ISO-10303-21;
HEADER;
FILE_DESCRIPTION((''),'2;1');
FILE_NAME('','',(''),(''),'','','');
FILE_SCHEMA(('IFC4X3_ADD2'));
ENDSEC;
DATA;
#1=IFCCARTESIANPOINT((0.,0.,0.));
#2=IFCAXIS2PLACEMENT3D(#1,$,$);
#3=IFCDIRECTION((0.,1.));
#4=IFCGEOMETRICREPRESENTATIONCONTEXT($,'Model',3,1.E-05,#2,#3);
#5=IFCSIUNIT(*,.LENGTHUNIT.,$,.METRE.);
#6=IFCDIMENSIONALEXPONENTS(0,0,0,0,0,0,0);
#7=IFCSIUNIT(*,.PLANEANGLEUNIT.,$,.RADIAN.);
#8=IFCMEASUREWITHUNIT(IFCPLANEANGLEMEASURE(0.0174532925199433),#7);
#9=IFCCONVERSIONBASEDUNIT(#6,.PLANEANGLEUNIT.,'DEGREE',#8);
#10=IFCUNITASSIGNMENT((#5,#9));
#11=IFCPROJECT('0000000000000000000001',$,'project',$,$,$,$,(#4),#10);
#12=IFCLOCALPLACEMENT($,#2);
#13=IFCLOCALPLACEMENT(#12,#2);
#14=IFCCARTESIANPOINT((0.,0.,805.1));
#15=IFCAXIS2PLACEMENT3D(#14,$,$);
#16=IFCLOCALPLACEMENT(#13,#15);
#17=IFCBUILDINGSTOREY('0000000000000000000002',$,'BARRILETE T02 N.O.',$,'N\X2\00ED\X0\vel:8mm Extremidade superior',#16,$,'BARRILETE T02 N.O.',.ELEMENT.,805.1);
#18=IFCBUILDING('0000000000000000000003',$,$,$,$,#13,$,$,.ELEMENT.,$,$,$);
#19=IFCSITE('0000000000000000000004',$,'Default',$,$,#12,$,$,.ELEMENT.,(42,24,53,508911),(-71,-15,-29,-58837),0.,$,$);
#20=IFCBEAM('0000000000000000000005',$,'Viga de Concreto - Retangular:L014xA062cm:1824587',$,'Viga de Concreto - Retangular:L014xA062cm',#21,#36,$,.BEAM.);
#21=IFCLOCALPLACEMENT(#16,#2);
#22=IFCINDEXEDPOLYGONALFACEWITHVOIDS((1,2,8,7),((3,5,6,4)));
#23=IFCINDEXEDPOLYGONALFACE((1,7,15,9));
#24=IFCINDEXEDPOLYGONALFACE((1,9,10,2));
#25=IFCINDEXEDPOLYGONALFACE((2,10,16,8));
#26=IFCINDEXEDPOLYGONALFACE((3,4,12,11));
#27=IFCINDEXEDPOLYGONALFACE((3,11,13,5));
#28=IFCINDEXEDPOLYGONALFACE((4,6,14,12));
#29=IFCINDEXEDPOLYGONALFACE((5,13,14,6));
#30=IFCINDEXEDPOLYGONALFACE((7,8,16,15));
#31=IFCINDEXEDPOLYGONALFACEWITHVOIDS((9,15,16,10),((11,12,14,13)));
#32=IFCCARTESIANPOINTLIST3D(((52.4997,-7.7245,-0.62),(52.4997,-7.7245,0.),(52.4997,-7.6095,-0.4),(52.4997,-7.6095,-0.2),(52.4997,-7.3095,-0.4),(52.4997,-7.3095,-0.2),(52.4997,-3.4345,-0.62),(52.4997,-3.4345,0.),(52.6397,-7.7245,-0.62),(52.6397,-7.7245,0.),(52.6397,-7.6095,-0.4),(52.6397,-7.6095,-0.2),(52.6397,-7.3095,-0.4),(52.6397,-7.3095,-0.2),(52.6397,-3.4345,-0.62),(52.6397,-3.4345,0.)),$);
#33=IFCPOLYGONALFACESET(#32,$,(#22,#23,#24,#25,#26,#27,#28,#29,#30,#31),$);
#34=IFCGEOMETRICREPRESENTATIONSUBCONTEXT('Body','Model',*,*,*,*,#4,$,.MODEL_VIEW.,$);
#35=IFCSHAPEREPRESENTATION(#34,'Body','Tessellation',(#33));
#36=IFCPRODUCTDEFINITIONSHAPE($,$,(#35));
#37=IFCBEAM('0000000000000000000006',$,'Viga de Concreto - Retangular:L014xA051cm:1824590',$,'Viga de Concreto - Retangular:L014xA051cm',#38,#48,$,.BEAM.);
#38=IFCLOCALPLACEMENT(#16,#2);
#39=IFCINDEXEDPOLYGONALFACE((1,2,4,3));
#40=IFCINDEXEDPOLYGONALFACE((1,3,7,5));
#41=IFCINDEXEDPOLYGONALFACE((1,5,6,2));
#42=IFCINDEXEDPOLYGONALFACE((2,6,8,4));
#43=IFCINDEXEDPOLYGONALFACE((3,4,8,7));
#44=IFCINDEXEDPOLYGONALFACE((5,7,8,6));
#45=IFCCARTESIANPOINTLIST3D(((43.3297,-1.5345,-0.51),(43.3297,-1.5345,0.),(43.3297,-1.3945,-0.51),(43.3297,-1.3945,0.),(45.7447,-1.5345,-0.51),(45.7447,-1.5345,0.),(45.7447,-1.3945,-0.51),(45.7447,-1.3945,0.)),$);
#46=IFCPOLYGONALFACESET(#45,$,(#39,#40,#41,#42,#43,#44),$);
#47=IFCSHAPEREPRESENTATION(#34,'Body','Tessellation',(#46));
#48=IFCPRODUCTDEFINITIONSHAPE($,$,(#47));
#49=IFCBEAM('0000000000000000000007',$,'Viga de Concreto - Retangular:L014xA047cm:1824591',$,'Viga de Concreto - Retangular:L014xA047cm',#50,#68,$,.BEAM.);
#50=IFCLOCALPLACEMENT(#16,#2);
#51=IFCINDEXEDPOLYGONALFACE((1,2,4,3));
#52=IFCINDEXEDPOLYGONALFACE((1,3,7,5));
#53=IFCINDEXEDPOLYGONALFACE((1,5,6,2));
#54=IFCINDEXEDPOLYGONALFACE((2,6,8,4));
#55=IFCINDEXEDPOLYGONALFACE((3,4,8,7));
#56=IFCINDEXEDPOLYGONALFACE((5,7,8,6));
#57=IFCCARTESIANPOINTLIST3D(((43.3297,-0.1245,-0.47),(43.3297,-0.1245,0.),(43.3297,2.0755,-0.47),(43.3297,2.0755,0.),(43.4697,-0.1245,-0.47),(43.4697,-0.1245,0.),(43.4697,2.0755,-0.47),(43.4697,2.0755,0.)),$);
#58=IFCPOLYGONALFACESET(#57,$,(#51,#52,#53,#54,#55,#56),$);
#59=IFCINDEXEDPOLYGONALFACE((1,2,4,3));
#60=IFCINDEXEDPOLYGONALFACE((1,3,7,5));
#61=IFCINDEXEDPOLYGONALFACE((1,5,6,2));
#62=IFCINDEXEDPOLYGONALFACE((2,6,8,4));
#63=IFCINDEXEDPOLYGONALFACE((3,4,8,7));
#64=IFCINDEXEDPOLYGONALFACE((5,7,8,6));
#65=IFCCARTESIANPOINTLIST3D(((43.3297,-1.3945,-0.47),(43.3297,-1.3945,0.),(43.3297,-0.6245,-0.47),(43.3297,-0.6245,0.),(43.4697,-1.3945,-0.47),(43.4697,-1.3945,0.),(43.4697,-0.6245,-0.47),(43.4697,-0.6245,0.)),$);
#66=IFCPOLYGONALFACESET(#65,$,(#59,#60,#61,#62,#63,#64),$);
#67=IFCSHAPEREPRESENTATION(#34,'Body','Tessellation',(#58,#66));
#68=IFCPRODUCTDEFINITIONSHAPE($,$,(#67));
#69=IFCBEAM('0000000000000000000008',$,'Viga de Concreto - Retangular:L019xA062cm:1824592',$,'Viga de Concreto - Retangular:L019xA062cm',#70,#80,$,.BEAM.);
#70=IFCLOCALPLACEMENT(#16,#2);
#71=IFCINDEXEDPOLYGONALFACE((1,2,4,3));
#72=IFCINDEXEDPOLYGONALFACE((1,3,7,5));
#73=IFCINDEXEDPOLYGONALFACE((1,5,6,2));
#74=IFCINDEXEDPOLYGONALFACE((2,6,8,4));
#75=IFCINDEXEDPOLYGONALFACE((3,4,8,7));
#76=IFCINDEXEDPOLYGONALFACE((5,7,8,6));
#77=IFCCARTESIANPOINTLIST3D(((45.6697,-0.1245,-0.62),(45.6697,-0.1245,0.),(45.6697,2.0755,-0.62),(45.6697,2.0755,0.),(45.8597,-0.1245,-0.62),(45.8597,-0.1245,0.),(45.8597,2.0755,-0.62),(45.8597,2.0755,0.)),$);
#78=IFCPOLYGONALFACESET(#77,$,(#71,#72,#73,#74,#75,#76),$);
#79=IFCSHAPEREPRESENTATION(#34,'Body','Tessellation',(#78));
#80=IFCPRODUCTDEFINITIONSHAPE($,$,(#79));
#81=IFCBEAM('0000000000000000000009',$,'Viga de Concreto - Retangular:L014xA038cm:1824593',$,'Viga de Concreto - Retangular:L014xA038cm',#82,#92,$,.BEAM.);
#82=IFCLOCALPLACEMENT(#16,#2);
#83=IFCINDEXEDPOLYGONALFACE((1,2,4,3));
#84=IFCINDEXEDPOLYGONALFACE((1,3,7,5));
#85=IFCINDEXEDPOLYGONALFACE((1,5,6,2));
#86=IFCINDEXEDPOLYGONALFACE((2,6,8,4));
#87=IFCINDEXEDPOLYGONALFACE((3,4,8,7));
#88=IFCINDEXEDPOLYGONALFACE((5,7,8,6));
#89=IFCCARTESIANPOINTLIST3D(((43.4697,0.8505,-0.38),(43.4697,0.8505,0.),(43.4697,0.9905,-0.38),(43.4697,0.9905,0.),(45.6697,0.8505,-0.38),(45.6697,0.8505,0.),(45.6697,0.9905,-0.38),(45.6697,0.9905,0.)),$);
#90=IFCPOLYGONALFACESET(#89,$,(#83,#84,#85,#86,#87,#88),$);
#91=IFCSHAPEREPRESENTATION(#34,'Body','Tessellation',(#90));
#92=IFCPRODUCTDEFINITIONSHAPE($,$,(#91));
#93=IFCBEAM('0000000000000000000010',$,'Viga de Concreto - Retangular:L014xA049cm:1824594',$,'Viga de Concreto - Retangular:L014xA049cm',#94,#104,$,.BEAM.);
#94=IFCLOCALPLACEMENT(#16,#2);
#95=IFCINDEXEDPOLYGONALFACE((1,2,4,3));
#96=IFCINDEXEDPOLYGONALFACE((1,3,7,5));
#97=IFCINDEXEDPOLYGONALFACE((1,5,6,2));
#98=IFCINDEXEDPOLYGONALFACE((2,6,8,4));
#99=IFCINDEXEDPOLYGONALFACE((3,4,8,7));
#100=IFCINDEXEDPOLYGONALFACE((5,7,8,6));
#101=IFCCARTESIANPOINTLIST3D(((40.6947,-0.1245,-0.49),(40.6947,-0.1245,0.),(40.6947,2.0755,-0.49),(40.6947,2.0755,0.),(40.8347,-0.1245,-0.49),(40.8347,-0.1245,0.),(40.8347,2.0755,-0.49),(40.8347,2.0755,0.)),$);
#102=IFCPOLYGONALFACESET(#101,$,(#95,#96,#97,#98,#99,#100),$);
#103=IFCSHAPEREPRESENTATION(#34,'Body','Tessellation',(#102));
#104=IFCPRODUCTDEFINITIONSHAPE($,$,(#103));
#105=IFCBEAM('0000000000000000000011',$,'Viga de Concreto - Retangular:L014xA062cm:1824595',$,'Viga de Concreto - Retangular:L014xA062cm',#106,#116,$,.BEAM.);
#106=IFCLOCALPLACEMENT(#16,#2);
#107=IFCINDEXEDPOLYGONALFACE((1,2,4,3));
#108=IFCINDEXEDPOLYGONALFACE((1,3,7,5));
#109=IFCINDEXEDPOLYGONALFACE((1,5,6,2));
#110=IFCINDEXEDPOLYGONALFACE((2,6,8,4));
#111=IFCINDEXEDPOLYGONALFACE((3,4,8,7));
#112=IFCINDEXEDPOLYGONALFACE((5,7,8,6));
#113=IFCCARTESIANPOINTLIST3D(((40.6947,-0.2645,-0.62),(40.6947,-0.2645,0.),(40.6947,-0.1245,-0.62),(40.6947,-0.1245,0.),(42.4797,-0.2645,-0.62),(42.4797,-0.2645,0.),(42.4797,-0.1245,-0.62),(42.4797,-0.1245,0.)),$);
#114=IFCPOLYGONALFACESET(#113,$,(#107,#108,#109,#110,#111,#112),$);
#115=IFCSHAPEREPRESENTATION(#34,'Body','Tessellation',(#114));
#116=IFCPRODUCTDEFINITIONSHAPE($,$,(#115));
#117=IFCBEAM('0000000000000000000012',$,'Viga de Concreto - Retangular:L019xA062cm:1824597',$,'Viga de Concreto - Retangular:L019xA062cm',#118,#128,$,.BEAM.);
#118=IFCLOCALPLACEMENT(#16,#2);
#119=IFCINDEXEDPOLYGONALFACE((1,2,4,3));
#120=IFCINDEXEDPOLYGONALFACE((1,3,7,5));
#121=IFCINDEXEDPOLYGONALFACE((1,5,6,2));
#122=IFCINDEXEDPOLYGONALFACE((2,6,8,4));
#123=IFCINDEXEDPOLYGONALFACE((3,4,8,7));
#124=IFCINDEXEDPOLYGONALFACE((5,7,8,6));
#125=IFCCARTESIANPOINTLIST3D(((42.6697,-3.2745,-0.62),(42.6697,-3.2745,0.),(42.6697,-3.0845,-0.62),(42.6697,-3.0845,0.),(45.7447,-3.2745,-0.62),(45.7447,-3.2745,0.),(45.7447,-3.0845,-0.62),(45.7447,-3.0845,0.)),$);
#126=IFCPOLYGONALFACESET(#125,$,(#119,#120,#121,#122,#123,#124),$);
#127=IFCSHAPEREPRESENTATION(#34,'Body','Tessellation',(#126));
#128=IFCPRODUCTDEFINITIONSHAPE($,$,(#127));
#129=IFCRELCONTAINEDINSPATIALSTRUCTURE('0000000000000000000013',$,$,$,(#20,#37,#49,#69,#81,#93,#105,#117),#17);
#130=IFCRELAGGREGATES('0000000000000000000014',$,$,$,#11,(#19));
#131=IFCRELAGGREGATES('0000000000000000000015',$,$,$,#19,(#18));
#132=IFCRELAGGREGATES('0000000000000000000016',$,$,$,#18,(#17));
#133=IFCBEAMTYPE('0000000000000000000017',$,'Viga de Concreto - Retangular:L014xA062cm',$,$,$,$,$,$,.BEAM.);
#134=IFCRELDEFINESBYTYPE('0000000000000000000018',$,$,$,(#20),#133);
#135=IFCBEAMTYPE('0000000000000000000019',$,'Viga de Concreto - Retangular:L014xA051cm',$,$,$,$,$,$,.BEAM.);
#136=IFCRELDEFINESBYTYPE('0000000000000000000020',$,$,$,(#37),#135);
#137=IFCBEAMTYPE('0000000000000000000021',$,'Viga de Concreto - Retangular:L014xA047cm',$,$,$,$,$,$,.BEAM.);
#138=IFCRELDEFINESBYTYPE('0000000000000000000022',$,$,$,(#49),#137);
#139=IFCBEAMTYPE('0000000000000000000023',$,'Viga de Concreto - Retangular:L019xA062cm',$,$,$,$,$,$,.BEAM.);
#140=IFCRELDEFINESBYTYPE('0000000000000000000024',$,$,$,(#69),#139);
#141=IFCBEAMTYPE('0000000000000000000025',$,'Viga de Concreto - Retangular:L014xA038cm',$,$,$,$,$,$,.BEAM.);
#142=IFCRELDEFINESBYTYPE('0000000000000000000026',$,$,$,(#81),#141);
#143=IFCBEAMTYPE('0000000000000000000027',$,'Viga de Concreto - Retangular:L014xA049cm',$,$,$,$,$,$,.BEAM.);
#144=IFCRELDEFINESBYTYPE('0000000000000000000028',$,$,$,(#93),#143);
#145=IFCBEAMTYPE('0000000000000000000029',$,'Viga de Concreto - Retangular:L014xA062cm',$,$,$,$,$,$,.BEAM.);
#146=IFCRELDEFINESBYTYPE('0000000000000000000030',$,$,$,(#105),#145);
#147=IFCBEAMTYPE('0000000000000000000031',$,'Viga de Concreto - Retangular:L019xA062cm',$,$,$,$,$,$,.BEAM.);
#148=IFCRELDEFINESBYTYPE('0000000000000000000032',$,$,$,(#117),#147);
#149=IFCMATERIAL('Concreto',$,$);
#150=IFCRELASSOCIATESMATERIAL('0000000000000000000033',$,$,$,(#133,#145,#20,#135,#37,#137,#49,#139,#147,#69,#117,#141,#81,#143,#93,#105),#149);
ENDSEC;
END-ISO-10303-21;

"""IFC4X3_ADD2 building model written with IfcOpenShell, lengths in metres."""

from ifc_helpers import new_model, entity, si_unit, converted_unit, direction, frame, frame_2d, origin, place, context, subcontext, project, spatial, polyline, segment, composite_curve, rectangle, outline, extrude, boolean, source, transform, mapped, material, material_profile, profile_set, profile_usage, type_object, type_shapes, element, save


model = new_model("IFC4X3_ADD2")

# Units and contexts
model_context = context("Model", 3, precision=1e-05, world=origin(), true_north=direction((0.0, 1.0)))
body_context = subcontext(model_context, "Body", "Model", "MODEL_VIEW")
ifc_project = project(units=[si_unit("LENGTHUNIT", "METRE"), converted_unit("PLANEANGLEUNIT", "DEGREE", entity("IfcPlaneAngleMeasure", 0.0174532925199433), si_unit("PLANEANGLEUNIT", "RADIAN"), dimensions=[0, 0, 0, 0, 0, 0, 0])], contexts=[model_context])

# Site, building, storey
site_placement = place(None, origin())
site = spatial("IfcSite", under=ifc_project, at=site_placement, Name="Default", CompositionType="ELEMENT", RefLatitude=(42, 24, 53, 508911), RefLongitude=(-71, -15, -29, -58837), RefElevation=0.0)
building_placement = place(site_placement, origin())
building = spatial("IfcBuilding", under=site, at=building_placement, CompositionType="ELEMENT")
storey_placement = place(building_placement, frame((0.0, 0.0, 805.1)))
storey = spatial("IfcBuildingStorey", under=building, at=storey_placement, Name="BARRILETE T02 N.O.", ObjectType="Nível:8mm Extremidade superior", LongName="BARRILETE T02 N.O.", CompositionType="ELEMENT", Elevation=805.1)

# Shared definitions
ifc_material = material(Name="Concreto")

# Beams
ifc_material_profile_1 = material_profile(ifc_material, rectangle(XDim=0.62, YDim=0.19, at=frame_2d((0.0, 0.0), x_axis=(0.0, 1.0))), Name="L019xA062cm")
ifc_profile_set_1 = profile_set([ifc_material_profile_1], Name="L019xA062cm")
ifc_material_profile_2 = material_profile(ifc_material, rectangle(XDim=0.49, YDim=0.14, at=frame_2d((0.0, 0.0), x_axis=(0.0, 1.0))), Name="L014xA049cm")
ifc_profile_set_2 = profile_set([ifc_material_profile_2], Name="L014xA049cm")
ifc_profile_usage_1 = profile_usage(ifc_profile_set_2, cardinal=8)
ifc_profile_usage_2 = profile_usage(ifc_profile_set_1, cardinal=8)
ifc_material_profile_3 = material_profile(ifc_material, outline(composite_curve([segment(polyline([(-0.07, 0.31, 0.0), (0.07, 0.31, 0.0)]), True, "CONTINUOUS"), segment(polyline([(0.07, 0.31, 0.0), (0.07, -0.31, 0.0)]), True, "CONTINUOUS"), segment(polyline([(0.07, -0.31, 0.0), (-0.07, -0.31, 0.0)]), True, "CONTINUOUS"), segment(polyline([(-0.07, -0.31, 0.0), (-0.07, 0.31, 0.0)]), True, "CONTINUOUS")], self_intersect=False), kind="CURVE"), Name="L014xA062cm")
ifc_material_profile_4 = material_profile(ifc_material, outline(composite_curve([segment(polyline([(-2.2225, 0.07, 0.31), (-2.2225, 0.07, -0.31)]), True, "CONTINUOUS"), segment(polyline([(-2.2225, 0.07, -0.31), (-2.2225, -0.07, -0.31)]), True, "CONTINUOUS"), segment(polyline([(-2.2225, -0.07, -0.31), (-2.2225, -0.07, 0.31)]), True, "CONTINUOUS"), segment(polyline([(-2.2225, -0.07, 0.31), (-2.2225, 0.07, 0.31)]), True, "CONTINUOUS")], self_intersect=False), kind="CURVE"), Name="L014xA062cm")
ifc_profile_set_3 = profile_set([ifc_material_profile_3, ifc_material_profile_4], Name="L014xA062cm")
beam_type_1 = type_object("IfcBeamType", Name="Viga de Concreto - Retangular:L014xA062cm", PredefinedType="BEAM", material=ifc_profile_set_3)
shared_shape_1 = source(origin(), body_context, "Body", "CSG", [
    boolean("DIFFERENCE", extrude(rectangle(XDim=0.62, YDim=0.14, at=frame_2d((0.0, 0.0), x_axis=(0.0, 1.0))), frame((52.5697, -7.7245, 804.79), z_axis=(0.0, 1.0, 0.0), x_axis=(-1.0, 0.0, 0.0)), (0.0, 0.0, 1.0), 4.29), extrude(rectangle(XDim=0.2, YDim=0.3, at=frame_2d((0.0, 0.0), x_axis=(0.0, 1.0))), frame((52.6397, -7.4595, 804.8), z_axis=(-1.0, 0.0, 0.0), x_axis=(0.0, 1.0, 0.0)), (0.0, 0.0, 1.0), 0.14)),
])
type_shapes(beam_type_1, [shared_shape_1])
beam_1_placement = place(storey_placement, frame((0.0, 0.0, -805.1)))
element("IfcBeam", 1, at=beam_1_placement, inside=storey, type_object=beam_type_1, material=ifc_material, Name="Viga de Concreto - Retangular:L014xA062cm:1824587", ObjectType="Viga de Concreto - Retangular:L014xA062cm", PredefinedType="BEAM", context=body_context, shape_type="MappedRepresentation", body=[
    mapped(shared_shape_1, transform((0.0, 0.0, 0.0), scale=1.0)),
])
ifc_material_profile_5 = material_profile(ifc_material, rectangle(XDim=0.51, YDim=0.14, at=frame_2d((0.0, 0.0), x_axis=(1.0, 0.0))), Name="L014xA051cm")
ifc_profile_set_4 = profile_set([ifc_material_profile_5], Name="L014xA051cm")
ifc_profile_usage_3 = profile_usage(ifc_profile_set_4, cardinal=8)
beam_type_2 = type_object("IfcBeamType", Name="Viga de Concreto - Retangular:L014xA051cm", PredefinedType="BEAM", material=ifc_profile_set_4)
shared_shape_2 = source(origin(), body_context, "Body", "SweptSolid", [
    extrude(rectangle(XDim=0.51, YDim=0.14, at=frame_2d((0.0, 0.0), x_axis=(1.0, 0.0))), frame((45.7447, -1.4645, 804.845), z_axis=(-1.0, 0.0, 0.0), x_axis=(0.0, 0.0, -1.0)), (0.0, 0.0, 1.0), 2.415),
])
type_shapes(beam_type_2, [shared_shape_2])
beam_2_placement = place(storey_placement, frame((0.0, 0.0, -805.1)))
element("IfcBeam", 2, at=beam_2_placement, inside=storey, type_object=beam_type_2, material=ifc_profile_usage_3, Name="Viga de Concreto - Retangular:L014xA051cm:1824590", ObjectType="Viga de Concreto - Retangular:L014xA051cm", PredefinedType="BEAM", context=body_context, shape_type="MappedRepresentation", body=[
    mapped(shared_shape_2, transform((0.0, 0.0, 0.0), scale=1.0)),
])
ifc_material_profile_6 = material_profile(ifc_material, rectangle(XDim=0.47, YDim=0.14, at=frame_2d((0.0, 0.0), x_axis=(0.0, 1.0))), Name="L014xA047cm")
ifc_profile_set_5 = profile_set([ifc_material_profile_6], Name="L014xA047cm")
ifc_profile_usage_4 = profile_usage(ifc_profile_set_5, cardinal=8)
beam_type_3 = type_object("IfcBeamType", Name="Viga de Concreto - Retangular:L014xA047cm", PredefinedType="BEAM", material=ifc_profile_set_5)
shared_shape_3 = source(origin(), body_context, "Body", "SweptSolid", [
    extrude(rectangle(XDim=0.47, YDim=0.14, at=frame_2d((0.0, 0.0), x_axis=(0.0, 1.0))), frame((43.3997, -0.1245, 804.865), z_axis=(0.0, 1.0, 0.0), x_axis=(-1.0, 0.0, 0.0)), (0.0, 0.0, 1.0), 2.2),
    extrude(rectangle(XDim=0.47, YDim=0.14, at=frame_2d((0.0, 0.0), x_axis=(0.0, 1.0))), frame((43.3997, -1.3945, 804.865), z_axis=(0.0, 1.0, 0.0), x_axis=(-1.0, 0.0, 0.0)), (0.0, 0.0, 1.0), 0.77),
])
type_shapes(beam_type_3, [shared_shape_3])
beam_3_placement = place(storey_placement, frame((0.0, 0.0, -805.1)))
element("IfcBeam", 3, at=beam_3_placement, inside=storey, type_object=beam_type_3, material=ifc_profile_usage_4, Name="Viga de Concreto - Retangular:L014xA047cm:1824591", ObjectType="Viga de Concreto - Retangular:L014xA047cm", PredefinedType="BEAM", context=body_context, shape_type="MappedRepresentation", body=[
    mapped(shared_shape_3, transform((0.0, 0.0, 0.0), scale=1.0)),
])
beam_type_4 = type_object("IfcBeamType", Name="Viga de Concreto - Retangular:L019xA062cm", PredefinedType="BEAM", material=ifc_profile_set_1)
shared_shape_4 = source(origin(), body_context, "Body", "SweptSolid", [
    extrude(rectangle(XDim=0.62, YDim=0.19, at=frame_2d((0.0, 0.0), x_axis=(0.0, 1.0))), frame((45.7647, 2.0755, 804.79), z_axis=(0.0, -1.0, 0.0), x_axis=(-1.0, 0.0, 0.0)), (0.0, 0.0, 1.0), 2.2),
])
type_shapes(beam_type_4, [shared_shape_4])
beam_4_placement = place(storey_placement, frame((0.0, 0.0, -805.1)))
element("IfcBeam", 4, at=beam_4_placement, inside=storey, type_object=beam_type_4, material=ifc_profile_usage_2, Name="Viga de Concreto - Retangular:L019xA062cm:1824592", ObjectType="Viga de Concreto - Retangular:L019xA062cm", PredefinedType="BEAM", context=body_context, shape_type="MappedRepresentation", body=[
    mapped(shared_shape_4, transform((0.0, 0.0, 0.0), scale=1.0)),
])
ifc_material_profile_7 = material_profile(ifc_material, rectangle(XDim=0.38, YDim=0.14, at=frame_2d((0.0, 0.0), x_axis=(1.0, 0.0))), Name="L014xA038cm")
ifc_profile_set_6 = profile_set([ifc_material_profile_7], Name="L014xA038cm")
ifc_profile_usage_5 = profile_usage(ifc_profile_set_6, cardinal=8)
beam_type_5 = type_object("IfcBeamType", Name="Viga de Concreto - Retangular:L014xA038cm", PredefinedType="BEAM", material=ifc_profile_set_6)
shared_shape_5 = source(origin(), body_context, "Body", "SweptSolid", [
    extrude(rectangle(XDim=0.38, YDim=0.14, at=frame_2d((0.0, 0.0), x_axis=(1.0, 0.0))), frame((43.4697, 0.9205, 804.91), z_axis=(1.0, 0.0, 0.0), x_axis=(0.0, 0.0, -1.0)), (0.0, 0.0, 1.0), 2.2),
])
type_shapes(beam_type_5, [shared_shape_5])
beam_5_placement = place(storey_placement, frame((0.0, 0.0, -805.1)))
element("IfcBeam", 5, at=beam_5_placement, inside=storey, type_object=beam_type_5, material=ifc_profile_usage_5, Name="Viga de Concreto - Retangular:L014xA038cm:1824593", ObjectType="Viga de Concreto - Retangular:L014xA038cm", PredefinedType="BEAM", context=body_context, shape_type="MappedRepresentation", body=[
    mapped(shared_shape_5, transform((0.0, 0.0, 0.0), scale=1.0)),
])
beam_type_6 = type_object("IfcBeamType", Name="Viga de Concreto - Retangular:L014xA049cm", PredefinedType="BEAM", material=ifc_profile_set_2)
shared_shape_6 = source(origin(), body_context, "Body", "SweptSolid", [
    extrude(rectangle(XDim=0.49, YDim=0.14, at=frame_2d((0.0, 0.0), x_axis=(0.0, 1.0))), frame((40.7647, 2.0755, 804.855), z_axis=(0.0, -1.0, 0.0), x_axis=(-1.0, 0.0, 0.0)), (0.0, 0.0, 1.0), 2.2),
])
type_shapes(beam_type_6, [shared_shape_6])
beam_6_placement = place(storey_placement, frame((0.0, 0.0, -805.1)))
element("IfcBeam", 6, at=beam_6_placement, inside=storey, type_object=beam_type_6, material=ifc_profile_usage_1, Name="Viga de Concreto - Retangular:L014xA049cm:1824594", ObjectType="Viga de Concreto - Retangular:L014xA049cm", PredefinedType="BEAM", context=body_context, shape_type="MappedRepresentation", body=[
    mapped(shared_shape_6, transform((0.0, 0.0, 0.0), scale=1.0)),
])
ifc_profile_usage_6 = profile_usage(ifc_profile_set_3, cardinal=8)
beam_type_7 = type_object("IfcBeamType", Name="Viga de Concreto - Retangular:L014xA062cm", PredefinedType="BEAM", material=ifc_profile_set_3)
shared_shape_7 = source(origin(), body_context, "Body", "SweptSolid", [
    extrude(rectangle(XDim=0.62, YDim=0.14, at=frame_2d((0.0, 0.0), x_axis=(1.0, 0.0))), frame((42.4797, -0.1945, 804.79), z_axis=(-1.0, 0.0, 0.0), x_axis=(0.0, 0.0, -1.0)), (0.0, 0.0, 1.0), 1.785),
])
type_shapes(beam_type_7, [shared_shape_7])
beam_7_placement = place(storey_placement, frame((0.0, 0.0, -805.1)))
element("IfcBeam", 7, at=beam_7_placement, inside=storey, type_object=beam_type_7, material=ifc_profile_usage_6, Name="Viga de Concreto - Retangular:L014xA062cm:1824595", ObjectType="Viga de Concreto - Retangular:L014xA062cm", PredefinedType="BEAM", context=body_context, shape_type="MappedRepresentation", body=[
    mapped(shared_shape_7, transform((0.0, 0.0, 0.0), scale=1.0)),
])
beam_type_8 = type_object("IfcBeamType", Name="Viga de Concreto - Retangular:L019xA062cm", PredefinedType="BEAM", material=ifc_profile_set_1)
shared_shape_8 = source(origin(), body_context, "Body", "SweptSolid", [
    extrude(rectangle(XDim=0.62, YDim=0.19, at=frame_2d((0.0, 0.0), x_axis=(1.0, 0.0))), frame((42.6697, -3.1795, 804.79), z_axis=(1.0, 0.0, 0.0), x_axis=(0.0, 0.0, -1.0)), (0.0, 0.0, 1.0), 3.075),
])
type_shapes(beam_type_8, [shared_shape_8])
beam_8_placement = place(storey_placement, frame((0.0, 0.0, -805.1)))
element("IfcBeam", 8, at=beam_8_placement, inside=storey, type_object=beam_type_8, material=ifc_profile_usage_2, Name="Viga de Concreto - Retangular:L019xA062cm:1824597", ObjectType="Viga de Concreto - Retangular:L019xA062cm", PredefinedType="BEAM", context=body_context, shape_type="MappedRepresentation", body=[
    mapped(shared_shape_8, transform((0.0, 0.0, 0.0), scale=1.0)),
])

save(model, "model.ifc")
